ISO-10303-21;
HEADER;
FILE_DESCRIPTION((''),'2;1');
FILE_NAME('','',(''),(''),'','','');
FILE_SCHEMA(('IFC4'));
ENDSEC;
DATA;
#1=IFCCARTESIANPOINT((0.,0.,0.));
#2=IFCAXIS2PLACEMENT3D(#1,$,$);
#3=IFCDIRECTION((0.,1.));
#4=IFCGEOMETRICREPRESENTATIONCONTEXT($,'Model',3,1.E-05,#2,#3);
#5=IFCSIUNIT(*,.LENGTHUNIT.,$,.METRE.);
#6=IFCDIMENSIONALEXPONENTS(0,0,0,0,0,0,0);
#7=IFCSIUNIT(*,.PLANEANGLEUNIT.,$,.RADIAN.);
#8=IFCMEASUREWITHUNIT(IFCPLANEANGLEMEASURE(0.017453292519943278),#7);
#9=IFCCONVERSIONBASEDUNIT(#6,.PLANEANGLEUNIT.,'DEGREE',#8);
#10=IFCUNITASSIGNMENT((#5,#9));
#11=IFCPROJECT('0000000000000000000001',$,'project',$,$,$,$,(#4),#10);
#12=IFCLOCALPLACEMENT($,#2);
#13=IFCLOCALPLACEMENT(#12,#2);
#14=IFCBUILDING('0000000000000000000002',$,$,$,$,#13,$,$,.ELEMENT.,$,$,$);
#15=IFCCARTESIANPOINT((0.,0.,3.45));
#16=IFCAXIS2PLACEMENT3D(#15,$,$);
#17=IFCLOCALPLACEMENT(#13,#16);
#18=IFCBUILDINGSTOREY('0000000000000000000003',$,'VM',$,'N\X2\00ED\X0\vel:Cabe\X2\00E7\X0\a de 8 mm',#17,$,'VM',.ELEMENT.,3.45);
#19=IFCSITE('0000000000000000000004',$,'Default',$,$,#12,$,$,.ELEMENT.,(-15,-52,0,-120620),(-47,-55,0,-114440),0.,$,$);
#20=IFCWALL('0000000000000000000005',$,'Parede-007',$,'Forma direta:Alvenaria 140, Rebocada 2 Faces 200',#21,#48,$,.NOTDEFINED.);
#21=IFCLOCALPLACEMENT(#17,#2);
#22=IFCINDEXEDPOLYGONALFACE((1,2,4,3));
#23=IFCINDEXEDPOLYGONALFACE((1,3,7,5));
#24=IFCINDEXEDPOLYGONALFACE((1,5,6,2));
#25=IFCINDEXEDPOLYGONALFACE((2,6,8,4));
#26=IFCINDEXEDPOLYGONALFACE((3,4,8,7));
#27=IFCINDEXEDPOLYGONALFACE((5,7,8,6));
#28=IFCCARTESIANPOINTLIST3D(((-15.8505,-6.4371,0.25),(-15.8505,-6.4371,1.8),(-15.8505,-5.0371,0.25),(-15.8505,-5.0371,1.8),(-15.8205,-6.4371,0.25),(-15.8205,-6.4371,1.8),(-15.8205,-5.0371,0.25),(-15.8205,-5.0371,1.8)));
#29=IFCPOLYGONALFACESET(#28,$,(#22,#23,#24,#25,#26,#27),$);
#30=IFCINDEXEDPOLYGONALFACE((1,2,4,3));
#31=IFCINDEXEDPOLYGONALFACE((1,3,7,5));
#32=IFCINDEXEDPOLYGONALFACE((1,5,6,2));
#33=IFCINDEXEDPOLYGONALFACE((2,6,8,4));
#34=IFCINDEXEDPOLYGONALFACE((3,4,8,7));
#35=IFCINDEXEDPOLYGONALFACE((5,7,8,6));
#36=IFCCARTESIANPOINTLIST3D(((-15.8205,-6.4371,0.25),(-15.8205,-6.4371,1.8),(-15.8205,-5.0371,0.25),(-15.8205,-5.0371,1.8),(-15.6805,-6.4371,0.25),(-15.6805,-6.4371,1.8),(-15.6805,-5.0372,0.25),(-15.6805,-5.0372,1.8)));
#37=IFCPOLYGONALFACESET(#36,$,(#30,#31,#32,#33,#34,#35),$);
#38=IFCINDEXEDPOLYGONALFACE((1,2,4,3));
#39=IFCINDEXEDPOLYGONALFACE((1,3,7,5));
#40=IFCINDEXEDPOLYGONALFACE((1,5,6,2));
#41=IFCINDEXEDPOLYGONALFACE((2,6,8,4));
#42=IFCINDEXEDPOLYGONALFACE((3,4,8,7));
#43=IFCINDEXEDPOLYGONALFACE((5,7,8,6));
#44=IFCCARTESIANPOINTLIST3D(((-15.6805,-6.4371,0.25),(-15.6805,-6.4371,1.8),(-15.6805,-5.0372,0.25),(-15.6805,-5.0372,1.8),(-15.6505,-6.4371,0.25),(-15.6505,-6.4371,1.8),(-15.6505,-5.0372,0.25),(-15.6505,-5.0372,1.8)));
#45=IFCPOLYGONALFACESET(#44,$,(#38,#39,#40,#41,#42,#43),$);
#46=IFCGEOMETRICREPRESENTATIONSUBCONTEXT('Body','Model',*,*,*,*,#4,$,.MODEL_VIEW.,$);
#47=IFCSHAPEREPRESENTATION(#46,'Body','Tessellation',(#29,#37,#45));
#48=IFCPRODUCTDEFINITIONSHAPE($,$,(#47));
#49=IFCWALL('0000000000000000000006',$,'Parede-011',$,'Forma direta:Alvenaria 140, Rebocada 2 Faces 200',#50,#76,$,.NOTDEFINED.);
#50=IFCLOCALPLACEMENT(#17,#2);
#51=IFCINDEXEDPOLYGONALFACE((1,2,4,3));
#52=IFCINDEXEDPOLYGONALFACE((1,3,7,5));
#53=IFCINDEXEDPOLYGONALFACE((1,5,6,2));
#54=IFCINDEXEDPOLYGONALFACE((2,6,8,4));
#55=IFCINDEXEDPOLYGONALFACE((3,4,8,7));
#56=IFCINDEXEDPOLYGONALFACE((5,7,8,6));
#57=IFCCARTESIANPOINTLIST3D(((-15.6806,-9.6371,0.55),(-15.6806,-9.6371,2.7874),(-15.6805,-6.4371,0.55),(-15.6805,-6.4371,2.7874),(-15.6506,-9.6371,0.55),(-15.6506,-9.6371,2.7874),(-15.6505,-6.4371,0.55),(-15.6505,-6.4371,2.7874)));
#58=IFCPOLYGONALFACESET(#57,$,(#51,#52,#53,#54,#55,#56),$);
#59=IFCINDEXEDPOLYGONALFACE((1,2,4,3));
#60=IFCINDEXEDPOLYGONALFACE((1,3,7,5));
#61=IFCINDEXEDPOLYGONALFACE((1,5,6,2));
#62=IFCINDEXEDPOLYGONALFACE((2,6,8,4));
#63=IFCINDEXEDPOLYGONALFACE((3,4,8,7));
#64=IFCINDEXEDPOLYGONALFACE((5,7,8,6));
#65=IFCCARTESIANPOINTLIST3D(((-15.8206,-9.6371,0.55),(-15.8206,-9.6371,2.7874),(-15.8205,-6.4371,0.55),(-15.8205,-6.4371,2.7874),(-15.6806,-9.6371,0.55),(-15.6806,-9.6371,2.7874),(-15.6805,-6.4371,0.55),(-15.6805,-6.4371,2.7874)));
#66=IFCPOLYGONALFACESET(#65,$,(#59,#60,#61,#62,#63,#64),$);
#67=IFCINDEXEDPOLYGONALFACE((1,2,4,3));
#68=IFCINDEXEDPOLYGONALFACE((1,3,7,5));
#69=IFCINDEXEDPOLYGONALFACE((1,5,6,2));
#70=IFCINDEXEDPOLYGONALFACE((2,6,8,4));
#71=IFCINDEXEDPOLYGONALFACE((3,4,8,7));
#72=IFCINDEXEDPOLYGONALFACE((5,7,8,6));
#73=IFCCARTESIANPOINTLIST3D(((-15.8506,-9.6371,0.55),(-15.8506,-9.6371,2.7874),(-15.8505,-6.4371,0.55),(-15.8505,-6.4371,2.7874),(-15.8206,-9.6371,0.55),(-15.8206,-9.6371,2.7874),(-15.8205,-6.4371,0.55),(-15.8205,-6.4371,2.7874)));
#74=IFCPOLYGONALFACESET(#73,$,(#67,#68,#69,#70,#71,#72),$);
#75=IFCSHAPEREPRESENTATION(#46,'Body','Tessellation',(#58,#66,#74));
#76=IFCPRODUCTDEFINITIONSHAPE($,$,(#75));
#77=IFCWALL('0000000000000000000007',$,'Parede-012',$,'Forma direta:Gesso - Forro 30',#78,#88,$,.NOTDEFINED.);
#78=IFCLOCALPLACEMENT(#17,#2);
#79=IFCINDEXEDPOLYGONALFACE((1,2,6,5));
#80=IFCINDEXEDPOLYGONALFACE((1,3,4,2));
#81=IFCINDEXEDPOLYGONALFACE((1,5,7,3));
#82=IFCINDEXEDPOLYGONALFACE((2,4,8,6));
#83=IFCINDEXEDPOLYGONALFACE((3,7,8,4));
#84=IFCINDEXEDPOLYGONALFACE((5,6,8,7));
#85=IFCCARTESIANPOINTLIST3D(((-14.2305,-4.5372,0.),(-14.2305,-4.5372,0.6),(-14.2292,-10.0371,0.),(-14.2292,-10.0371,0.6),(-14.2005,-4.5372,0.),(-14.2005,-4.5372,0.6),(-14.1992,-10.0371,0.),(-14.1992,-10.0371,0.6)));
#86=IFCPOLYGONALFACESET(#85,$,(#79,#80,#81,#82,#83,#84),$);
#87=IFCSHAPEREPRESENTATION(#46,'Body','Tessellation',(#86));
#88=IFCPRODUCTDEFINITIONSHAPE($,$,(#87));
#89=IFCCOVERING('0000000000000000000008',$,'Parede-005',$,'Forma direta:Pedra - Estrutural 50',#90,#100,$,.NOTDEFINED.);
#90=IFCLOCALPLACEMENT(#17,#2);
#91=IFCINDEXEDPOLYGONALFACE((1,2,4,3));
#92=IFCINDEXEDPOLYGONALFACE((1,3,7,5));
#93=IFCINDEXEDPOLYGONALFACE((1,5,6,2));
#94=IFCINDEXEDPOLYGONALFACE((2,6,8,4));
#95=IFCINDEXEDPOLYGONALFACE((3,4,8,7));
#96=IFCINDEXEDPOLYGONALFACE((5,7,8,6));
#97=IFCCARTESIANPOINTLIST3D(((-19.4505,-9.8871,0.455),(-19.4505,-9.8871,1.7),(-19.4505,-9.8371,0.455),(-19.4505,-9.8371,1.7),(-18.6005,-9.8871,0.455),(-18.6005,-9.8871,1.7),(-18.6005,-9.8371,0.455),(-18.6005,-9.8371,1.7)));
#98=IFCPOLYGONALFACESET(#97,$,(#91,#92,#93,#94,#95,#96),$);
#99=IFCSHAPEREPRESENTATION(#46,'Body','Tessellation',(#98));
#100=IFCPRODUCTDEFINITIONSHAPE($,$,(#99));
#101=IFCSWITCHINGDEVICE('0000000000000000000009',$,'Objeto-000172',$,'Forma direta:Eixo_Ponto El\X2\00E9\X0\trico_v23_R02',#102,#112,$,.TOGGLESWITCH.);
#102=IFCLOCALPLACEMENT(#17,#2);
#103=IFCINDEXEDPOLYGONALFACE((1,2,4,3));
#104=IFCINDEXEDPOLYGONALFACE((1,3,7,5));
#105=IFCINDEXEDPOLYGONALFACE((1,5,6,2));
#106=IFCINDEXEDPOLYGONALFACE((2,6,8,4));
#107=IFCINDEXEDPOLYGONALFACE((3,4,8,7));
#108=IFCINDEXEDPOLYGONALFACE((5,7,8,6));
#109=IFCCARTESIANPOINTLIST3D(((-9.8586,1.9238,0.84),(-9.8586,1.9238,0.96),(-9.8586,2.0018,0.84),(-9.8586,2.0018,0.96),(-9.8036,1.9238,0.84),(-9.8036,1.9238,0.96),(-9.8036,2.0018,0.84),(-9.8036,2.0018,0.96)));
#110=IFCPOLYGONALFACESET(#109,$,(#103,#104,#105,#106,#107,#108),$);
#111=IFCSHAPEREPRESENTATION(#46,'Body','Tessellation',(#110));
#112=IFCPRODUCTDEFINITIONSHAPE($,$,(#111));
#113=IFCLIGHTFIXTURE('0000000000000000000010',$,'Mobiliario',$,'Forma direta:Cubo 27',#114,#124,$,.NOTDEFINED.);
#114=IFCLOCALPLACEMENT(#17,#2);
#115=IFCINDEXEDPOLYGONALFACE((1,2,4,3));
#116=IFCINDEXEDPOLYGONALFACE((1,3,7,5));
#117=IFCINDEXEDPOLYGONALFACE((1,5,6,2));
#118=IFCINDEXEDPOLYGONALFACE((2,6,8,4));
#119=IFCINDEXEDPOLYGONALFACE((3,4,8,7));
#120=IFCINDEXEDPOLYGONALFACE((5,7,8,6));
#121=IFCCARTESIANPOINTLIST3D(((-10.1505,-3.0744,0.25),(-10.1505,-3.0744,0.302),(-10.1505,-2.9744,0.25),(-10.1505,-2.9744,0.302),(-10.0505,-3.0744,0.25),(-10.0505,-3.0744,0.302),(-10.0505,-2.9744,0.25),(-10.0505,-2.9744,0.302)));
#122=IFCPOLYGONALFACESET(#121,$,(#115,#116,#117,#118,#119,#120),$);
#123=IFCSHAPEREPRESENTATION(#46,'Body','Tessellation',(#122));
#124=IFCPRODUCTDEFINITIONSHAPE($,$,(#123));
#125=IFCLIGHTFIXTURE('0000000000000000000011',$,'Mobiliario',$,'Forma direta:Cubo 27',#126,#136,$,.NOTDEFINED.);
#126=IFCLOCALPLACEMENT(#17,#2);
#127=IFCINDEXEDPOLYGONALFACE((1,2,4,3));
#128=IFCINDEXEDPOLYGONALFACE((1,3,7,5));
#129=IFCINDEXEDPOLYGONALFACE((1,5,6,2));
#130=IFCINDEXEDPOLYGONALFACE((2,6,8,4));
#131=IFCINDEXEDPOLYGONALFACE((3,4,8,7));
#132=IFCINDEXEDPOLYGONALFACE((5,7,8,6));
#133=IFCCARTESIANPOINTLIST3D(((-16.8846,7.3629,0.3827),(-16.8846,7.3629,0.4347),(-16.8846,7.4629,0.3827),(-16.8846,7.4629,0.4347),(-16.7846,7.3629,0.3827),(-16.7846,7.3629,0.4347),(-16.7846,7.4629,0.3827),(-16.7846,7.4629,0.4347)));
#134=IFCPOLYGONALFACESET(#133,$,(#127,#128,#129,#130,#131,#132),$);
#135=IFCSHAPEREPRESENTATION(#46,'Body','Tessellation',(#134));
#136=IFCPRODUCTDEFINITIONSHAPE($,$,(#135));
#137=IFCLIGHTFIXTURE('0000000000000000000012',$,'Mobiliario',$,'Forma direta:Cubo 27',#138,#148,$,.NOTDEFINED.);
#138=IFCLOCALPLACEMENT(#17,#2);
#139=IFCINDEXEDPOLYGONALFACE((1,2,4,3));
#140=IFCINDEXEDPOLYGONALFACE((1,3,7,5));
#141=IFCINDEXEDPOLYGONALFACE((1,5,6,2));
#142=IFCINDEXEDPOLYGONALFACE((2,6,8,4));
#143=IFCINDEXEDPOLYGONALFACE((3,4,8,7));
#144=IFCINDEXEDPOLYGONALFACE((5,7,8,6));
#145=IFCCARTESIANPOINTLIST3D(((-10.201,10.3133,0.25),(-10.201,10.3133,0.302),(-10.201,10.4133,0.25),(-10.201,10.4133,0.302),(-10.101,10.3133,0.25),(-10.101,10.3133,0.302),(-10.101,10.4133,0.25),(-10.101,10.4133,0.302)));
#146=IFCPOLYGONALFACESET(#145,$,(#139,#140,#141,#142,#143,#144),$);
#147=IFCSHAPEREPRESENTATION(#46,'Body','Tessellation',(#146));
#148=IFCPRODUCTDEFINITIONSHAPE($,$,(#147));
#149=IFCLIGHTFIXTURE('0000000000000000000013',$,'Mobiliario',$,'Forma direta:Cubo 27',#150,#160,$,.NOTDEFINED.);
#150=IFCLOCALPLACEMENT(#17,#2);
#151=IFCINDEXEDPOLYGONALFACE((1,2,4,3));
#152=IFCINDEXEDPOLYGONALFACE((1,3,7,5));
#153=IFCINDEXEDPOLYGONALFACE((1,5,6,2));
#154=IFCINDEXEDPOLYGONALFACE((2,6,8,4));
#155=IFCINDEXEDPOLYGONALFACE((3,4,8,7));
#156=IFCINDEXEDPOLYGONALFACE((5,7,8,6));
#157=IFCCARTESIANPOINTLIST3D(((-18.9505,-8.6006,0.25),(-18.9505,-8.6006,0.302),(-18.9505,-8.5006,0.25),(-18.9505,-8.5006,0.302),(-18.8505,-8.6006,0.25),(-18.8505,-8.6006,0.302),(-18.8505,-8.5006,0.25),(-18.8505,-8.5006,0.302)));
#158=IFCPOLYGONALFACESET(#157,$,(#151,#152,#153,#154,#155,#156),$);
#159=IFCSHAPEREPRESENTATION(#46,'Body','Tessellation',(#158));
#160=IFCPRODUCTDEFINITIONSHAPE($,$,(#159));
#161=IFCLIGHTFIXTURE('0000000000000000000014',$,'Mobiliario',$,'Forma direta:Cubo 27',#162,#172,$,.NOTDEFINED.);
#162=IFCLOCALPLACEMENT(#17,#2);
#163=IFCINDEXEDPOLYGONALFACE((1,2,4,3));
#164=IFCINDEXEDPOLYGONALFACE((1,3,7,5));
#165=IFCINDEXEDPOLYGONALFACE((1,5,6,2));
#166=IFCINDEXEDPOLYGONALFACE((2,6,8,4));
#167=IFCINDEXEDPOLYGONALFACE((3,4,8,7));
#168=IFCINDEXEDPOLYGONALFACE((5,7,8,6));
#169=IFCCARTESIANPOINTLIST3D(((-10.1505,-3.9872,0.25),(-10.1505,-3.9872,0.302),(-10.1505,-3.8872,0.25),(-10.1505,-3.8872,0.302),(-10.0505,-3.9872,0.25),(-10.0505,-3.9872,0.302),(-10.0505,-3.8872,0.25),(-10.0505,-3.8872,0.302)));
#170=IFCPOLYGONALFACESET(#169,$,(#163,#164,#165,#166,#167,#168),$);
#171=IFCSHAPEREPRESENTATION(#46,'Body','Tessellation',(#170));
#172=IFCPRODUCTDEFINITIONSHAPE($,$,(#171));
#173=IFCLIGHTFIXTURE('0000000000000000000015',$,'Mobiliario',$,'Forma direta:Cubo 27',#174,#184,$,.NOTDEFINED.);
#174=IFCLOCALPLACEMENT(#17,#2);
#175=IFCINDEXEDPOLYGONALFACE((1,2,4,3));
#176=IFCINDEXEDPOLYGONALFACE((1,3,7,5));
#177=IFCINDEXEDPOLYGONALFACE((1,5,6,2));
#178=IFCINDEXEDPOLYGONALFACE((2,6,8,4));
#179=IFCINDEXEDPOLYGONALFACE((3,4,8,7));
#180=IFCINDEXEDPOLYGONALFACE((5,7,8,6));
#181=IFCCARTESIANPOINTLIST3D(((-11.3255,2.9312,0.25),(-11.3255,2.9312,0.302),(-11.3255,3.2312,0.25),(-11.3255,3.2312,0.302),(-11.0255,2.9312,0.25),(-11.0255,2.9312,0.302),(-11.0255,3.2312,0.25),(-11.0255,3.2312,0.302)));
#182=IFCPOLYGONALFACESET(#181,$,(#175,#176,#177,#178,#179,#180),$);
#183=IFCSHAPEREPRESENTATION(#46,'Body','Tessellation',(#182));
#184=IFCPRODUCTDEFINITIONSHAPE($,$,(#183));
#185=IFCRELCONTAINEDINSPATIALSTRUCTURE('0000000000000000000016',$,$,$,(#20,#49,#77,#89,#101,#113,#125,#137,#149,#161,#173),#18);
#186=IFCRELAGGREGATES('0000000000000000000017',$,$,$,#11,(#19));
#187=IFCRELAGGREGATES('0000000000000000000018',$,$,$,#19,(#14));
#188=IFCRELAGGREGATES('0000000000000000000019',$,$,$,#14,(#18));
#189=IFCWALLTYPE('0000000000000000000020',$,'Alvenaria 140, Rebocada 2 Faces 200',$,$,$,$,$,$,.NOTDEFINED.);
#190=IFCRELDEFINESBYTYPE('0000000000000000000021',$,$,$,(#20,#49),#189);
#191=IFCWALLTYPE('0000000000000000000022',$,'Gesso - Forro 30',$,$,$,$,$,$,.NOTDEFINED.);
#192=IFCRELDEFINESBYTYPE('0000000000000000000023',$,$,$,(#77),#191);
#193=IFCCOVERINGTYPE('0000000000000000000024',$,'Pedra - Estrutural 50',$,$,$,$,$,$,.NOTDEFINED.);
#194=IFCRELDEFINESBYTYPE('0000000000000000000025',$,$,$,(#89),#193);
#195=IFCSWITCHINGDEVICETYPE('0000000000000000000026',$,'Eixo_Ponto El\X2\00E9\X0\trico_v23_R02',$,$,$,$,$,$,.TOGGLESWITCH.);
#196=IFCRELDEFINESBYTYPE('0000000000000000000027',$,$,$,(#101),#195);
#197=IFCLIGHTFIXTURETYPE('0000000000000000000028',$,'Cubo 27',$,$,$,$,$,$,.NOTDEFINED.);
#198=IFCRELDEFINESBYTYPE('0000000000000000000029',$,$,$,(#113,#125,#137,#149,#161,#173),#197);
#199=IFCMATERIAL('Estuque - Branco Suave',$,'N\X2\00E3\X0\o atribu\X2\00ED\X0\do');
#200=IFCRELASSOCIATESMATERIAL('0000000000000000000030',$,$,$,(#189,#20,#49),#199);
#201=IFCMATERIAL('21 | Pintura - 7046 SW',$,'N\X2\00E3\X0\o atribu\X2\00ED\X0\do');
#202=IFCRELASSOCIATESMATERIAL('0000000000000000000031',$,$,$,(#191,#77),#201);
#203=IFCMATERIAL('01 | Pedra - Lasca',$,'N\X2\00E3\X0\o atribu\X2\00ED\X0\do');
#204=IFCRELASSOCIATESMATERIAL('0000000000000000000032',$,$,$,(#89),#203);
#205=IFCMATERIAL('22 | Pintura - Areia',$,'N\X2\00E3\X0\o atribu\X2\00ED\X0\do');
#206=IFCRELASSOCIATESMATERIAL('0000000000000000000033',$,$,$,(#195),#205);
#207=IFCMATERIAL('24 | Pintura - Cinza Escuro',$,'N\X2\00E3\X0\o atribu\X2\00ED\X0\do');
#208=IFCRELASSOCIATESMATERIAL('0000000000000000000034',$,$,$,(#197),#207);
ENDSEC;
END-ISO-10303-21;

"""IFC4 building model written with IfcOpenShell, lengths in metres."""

from ifc_helpers import new_model, entity, si_unit, converted_unit, direction, frame, origin, place, context, subcontext, project, spatial, indexed_curve, outline, extrude, material, type_object, element, save


model = new_model("IFC4")

# Units and contexts
model_context = context("Model", 3, precision=1e-05, world=origin(), true_north=direction((0.0, 1.0)))
body_context = subcontext(model_context, "Body", "Model", "MODEL_VIEW")
ifc_project = project(units=[si_unit("LENGTHUNIT", "METRE"), converted_unit("PLANEANGLEUNIT", "DEGREE", entity("IfcPlaneAngleMeasure", 0.017453292519943278), si_unit("PLANEANGLEUNIT", "RADIAN"), dimensions=[0, 0, 0, 0, 0, 0, 0])], contexts=[model_context])

# Site, building, storey
site_placement = place(None, origin())
site = spatial("IfcSite", under=ifc_project, at=site_placement, Name="Default", CompositionType="ELEMENT", RefLatitude=(-15, -52, 0, -120620), RefLongitude=(-47, -55, 0, -114440), RefElevation=0.0)
building_placement = place(site_placement, origin())
building = spatial("IfcBuilding", under=site, at=building_placement, CompositionType="ELEMENT")
storey_placement = place(building_placement, frame((0.0, 0.0, 3.45)))
storey = spatial("IfcBuildingStorey", under=building, at=storey_placement, Name="VM", ObjectType="Nível:Cabeça de 8 mm", LongName="VM", CompositionType="ELEMENT", Elevation=3.45)

# Wall
ifc_material_1 = material(Name="Estuque - Branco Suave", Category="Não atribuído")
wall_type_1 = type_object("IfcWallType", Name="Alvenaria 140, Rebocada 2 Faces 200", PredefinedType="NOTDEFINED", material=ifc_material_1)
wall_1_placement = place(storey_placement, frame((-15.8505, -6.4371, 0.25), z_axis=(0.0, 0.0, 1.0), x_axis=(0.0, 1.0, 0.0)))
element("IfcWall", 1, at=wall_1_placement, inside=storey, type_object=wall_type_1, material=ifc_material_1, Name="Parede-007", ObjectType="Forma direta:Alvenaria 140, Rebocada 2 Faces 200", PredefinedType="NOTDEFINED", context=body_context, shape_type="SweptSolid", body=[
    extrude(outline(indexed_curve([(-0.015, -0.7), (0.015, -0.7), (0.015, 0.7), (-0.015, 0.7), (-0.015, -0.7)], self_intersect=False)), frame((0.7, -0.015, 0.0), z_axis=(0.0, 0.0, 1.0), x_axis=(0.00002, 1.0, 0.0)), (0.0, 0.0, 1.0), 1.55),
    extrude(outline(indexed_curve([(-0.07, -0.7), (0.07, -0.7), (0.07, 0.7), (-0.07, 0.7), (-0.07, -0.7)], self_intersect=False)), frame((0.7, -0.1, 0.0), z_axis=(0.0, 0.0, 1.0), x_axis=(-0.00002, -1.0, 0.0)), (0.0, 0.0, 1.0), 1.55),
    extrude(outline(indexed_curve([(-0.015, -0.7), (0.015, -0.7), (0.015, 0.7), (-0.015, 0.7), (-0.015, -0.7)], self_intersect=False)), frame((0.7, -0.185, 0.0), z_axis=(0.0, 0.0, 1.0), x_axis=(-0.00002, -1.0, 0.0)), (0.0, 0.0, 1.0), 1.55),
])

# Walls
wall_2_placement = place(storey_placement, frame((-15.8506, -9.8371, 0.55), z_axis=(0.0, 0.0, 1.0), x_axis=(0.0, 1.0, 0.0)))
element("IfcWall", 2, at=wall_2_placement, inside=storey, type_object=wall_type_1, material=ifc_material_1, Name="Parede-011", ObjectType="Forma direta:Alvenaria 140, Rebocada 2 Faces 200", PredefinedType="NOTDEFINED", context=body_context, shape_type="SweptSolid", body=[
    extrude(outline(indexed_curve([(-0.015, -1.6), (0.015, -1.6), (0.015, 1.6), (-0.015, 1.6), (-0.015, -1.6)], self_intersect=False)), frame((1.8, -0.185, 0.0), z_axis=(0.0, 0.0, 1.0), x_axis=(-0.000011, -1.0, 0.0)), (0.0, 0.0, 1.0), 2.2374),
    extrude(outline(indexed_curve([(-0.07, -1.6), (0.07, -1.6), (0.07, 1.6), (-0.07, 1.6), (-0.07, -1.6)], self_intersect=False)), frame((1.8, -0.1, 0.0), z_axis=(0.0, 0.0, 1.0), x_axis=(0.000013, 1.0, 0.0)), (0.0, 0.0, 1.0), 2.2374),
    extrude(outline(indexed_curve([(-0.015, -1.6), (0.015, -1.6), (0.015, 1.6), (-0.015, 1.6), (-0.015, -1.6)], self_intersect=False)), frame((1.8, -0.015, 0.0), z_axis=(0.0, 0.0, 1.0), x_axis=(0.000013, 1.0, 0.0)), (0.0, 0.0, 1.0), 2.2374),
])
ifc_material_2 = material(Name="21 | Pintura - 7046 SW", Category="Não atribuído")
wall_type_2 = type_object("IfcWallType", Name="Gesso - Forro 30", PredefinedType="NOTDEFINED", material=ifc_material_2)
wall_3_placement = place(storey_placement, frame((-14.2305, -10.0371, 0.0), z_axis=(0.0, 0.0, 1.0), x_axis=(0.0, 1.0, 0.0)))
element("IfcWall", 3, at=wall_3_placement, inside=storey, type_object=wall_type_2, material=ifc_material_2, Name="Parede-012", ObjectType="Forma direta:Gesso - Forro 30", PredefinedType="NOTDEFINED", context=body_context, shape_type="SweptSolid", body=[
    extrude(outline(indexed_curve([(-0.015, -2.75), (0.015, -2.75), (0.015, 2.75), (-0.015, 2.75), (-0.015, -2.75)], self_intersect=False)), frame((2.75, -0.0157, 0.0), z_axis=(0.0, 0.0, 1.0), x_axis=(0.000237, -1.0, 0.0)), (0.0, 0.0, 1.0), 0.6),
])

# Covering
ifc_material_3 = material(Name="01 | Pedra - Lasca", Category="Não atribuído")
covering_type = type_object("IfcCoveringType", Name="Pedra - Estrutural 50", PredefinedType="NOTDEFINED")
covering_placement = place(storey_placement, origin())
element("IfcCovering", 4, at=covering_placement, inside=storey, type_object=covering_type, material=ifc_material_3, Name="Parede-005", ObjectType="Forma direta:Pedra - Estrutural 50", PredefinedType="NOTDEFINED", context=body_context, shape_type="SweptSolid", body=[
    extrude(outline(indexed_curve([(-0.025, -0.425), (0.025, -0.425), (0.025, 0.425), (-0.025, 0.425), (-0.025, -0.425)], self_intersect=False)), frame((-19.0255, -9.8621, 0.455), z_axis=(0.0, 0.0, 1.0), x_axis=(-0.000013, -1.0, 0.0)), (0.0, 0.0, 1.0), 1.245),
])

# Switching device
ifc_material_4 = material(Name="22 | Pintura - Areia", Category="Não atribuído")
switching_device_type = type_object("IfcSwitchingDeviceType", Name="Eixo_Ponto Elétrico_v23_R02", PredefinedType="TOGGLESWITCH", material=ifc_material_4)
switching_device_placement = place(storey_placement, origin())
element("IfcSwitchingDevice", 5, at=switching_device_placement, inside=storey, type_object=switching_device_type, Name="Objeto-000172", ObjectType="Forma direta:Eixo_Ponto Elétrico_v23_R02", PredefinedType="TOGGLESWITCH", context=body_context, shape_type="SweptSolid", body=[
    extrude(outline(indexed_curve([(-0.0275, -0.039), (0.0275, -0.039), (0.0275, 0.039), (-0.0275, 0.039), (-0.0275, -0.039)], self_intersect=False)), frame((-9.8311, 1.9628, 0.84)), (0.0, 0.0, 1.0), 0.12),
])

# Light fixtures
ifc_material_5 = material(Name="24 | Pintura - Cinza Escuro", Category="Não atribuído")
light_fixture_type = type_object("IfcLightFixtureType", Name="Cubo 27", PredefinedType="NOTDEFINED", material=ifc_material_5)
light_fixture_1_placement = place(storey_placement, origin())
element("IfcLightFixture", 6, at=light_fixture_1_placement, inside=storey, type_object=light_fixture_type, Name="Mobiliario", ObjectType="Forma direta:Cubo 27", PredefinedType="NOTDEFINED", context=body_context, shape_type="SweptSolid", body=[
    extrude(outline(indexed_curve([(-0.05, -0.05), (0.05, -0.05), (0.05, 0.05), (-0.05, 0.05), (-0.05, -0.05)], self_intersect=False)), frame((-10.1005, -3.0244, 0.25), z_axis=(0.0, 0.0, 1.0), x_axis=(-0.000013, -1.0, 0.0)), (0.0, 0.0, 1.0), 0.052),
])
light_fixture_2_placement = place(storey_placement, origin())
element("IfcLightFixture", 7, at=light_fixture_2_placement, inside=storey, type_object=light_fixture_type, Name="Mobiliario", ObjectType="Forma direta:Cubo 27", PredefinedType="NOTDEFINED", context=body_context, shape_type="SweptSolid", body=[
    extrude(outline(indexed_curve([(-0.05, -0.05), (0.05, -0.05), (0.05, 0.05), (-0.05, 0.05), (-0.05, -0.05)], self_intersect=False)), frame((-16.8346, 7.4129, 0.3827), z_axis=(0.0, 0.0, 1.0), x_axis=(-0.000013, -1.0, 0.0)), (0.0, 0.0, 1.0), 0.052),
])
light_fixture_3_placement = place(storey_placement, origin())
element("IfcLightFixture", 8, at=light_fixture_3_placement, inside=storey, type_object=light_fixture_type, Name="Mobiliario", ObjectType="Forma direta:Cubo 27", PredefinedType="NOTDEFINED", context=body_context, shape_type="SweptSolid", body=[
    extrude(outline(indexed_curve([(-0.05, -0.05), (0.05, -0.05), (0.05, 0.05), (-0.05, 0.05), (-0.05, -0.05)], self_intersect=False)), frame((-10.151, 10.3633, 0.25), z_axis=(0.0, 0.0, 1.0), x_axis=(-0.000013, -1.0, 0.0)), (0.0, 0.0, 1.0), 0.052),
])
light_fixture_4_placement = place(storey_placement, origin())
element("IfcLightFixture", 9, at=light_fixture_4_placement, inside=storey, type_object=light_fixture_type, Name="Mobiliario", ObjectType="Forma direta:Cubo 27", PredefinedType="NOTDEFINED", context=body_context, shape_type="SweptSolid", body=[
    extrude(outline(indexed_curve([(-0.05, -0.05), (0.05, -0.05), (0.05, 0.05), (-0.05, 0.05), (-0.05, -0.05)], self_intersect=False)), frame((-18.9005, -8.5506, 0.25), z_axis=(0.0, 0.0, 1.0), x_axis=(-0.000013, -1.0, 0.0)), (0.0, 0.0, 1.0), 0.052),
])
light_fixture_5_placement = place(storey_placement, origin())
element("IfcLightFixture", 10, at=light_fixture_5_placement, inside=storey, type_object=light_fixture_type, Name="Mobiliario", ObjectType="Forma direta:Cubo 27", PredefinedType="NOTDEFINED", context=body_context, shape_type="SweptSolid", body=[
    extrude(outline(indexed_curve([(-0.05, -0.05), (0.05, -0.05), (0.05, 0.05), (-0.05, 0.05), (-0.05, -0.05)], self_intersect=False)), frame((-10.1005, -3.9372, 0.25), z_axis=(0.0, 0.0, 1.0), x_axis=(-0.000013, -1.0, 0.0)), (0.0, 0.0, 1.0), 0.052),
])
light_fixture_6_placement = place(storey_placement, origin())
element("IfcLightFixture", 11, at=light_fixture_6_placement, inside=storey, type_object=light_fixture_type, Name="Mobiliario", ObjectType="Forma direta:Cubo 27", PredefinedType="NOTDEFINED", context=body_context, shape_type="SweptSolid", body=[
    extrude(outline(indexed_curve([(-0.15, -0.15), (0.15, -0.15), (0.15, 0.15), (-0.15, 0.15), (-0.15, -0.15)], self_intersect=False)), frame((-11.1755, 3.0812, 0.25)), (0.0, 0.0, 1.0), 0.052),
])

save(model, "model.ifc")
